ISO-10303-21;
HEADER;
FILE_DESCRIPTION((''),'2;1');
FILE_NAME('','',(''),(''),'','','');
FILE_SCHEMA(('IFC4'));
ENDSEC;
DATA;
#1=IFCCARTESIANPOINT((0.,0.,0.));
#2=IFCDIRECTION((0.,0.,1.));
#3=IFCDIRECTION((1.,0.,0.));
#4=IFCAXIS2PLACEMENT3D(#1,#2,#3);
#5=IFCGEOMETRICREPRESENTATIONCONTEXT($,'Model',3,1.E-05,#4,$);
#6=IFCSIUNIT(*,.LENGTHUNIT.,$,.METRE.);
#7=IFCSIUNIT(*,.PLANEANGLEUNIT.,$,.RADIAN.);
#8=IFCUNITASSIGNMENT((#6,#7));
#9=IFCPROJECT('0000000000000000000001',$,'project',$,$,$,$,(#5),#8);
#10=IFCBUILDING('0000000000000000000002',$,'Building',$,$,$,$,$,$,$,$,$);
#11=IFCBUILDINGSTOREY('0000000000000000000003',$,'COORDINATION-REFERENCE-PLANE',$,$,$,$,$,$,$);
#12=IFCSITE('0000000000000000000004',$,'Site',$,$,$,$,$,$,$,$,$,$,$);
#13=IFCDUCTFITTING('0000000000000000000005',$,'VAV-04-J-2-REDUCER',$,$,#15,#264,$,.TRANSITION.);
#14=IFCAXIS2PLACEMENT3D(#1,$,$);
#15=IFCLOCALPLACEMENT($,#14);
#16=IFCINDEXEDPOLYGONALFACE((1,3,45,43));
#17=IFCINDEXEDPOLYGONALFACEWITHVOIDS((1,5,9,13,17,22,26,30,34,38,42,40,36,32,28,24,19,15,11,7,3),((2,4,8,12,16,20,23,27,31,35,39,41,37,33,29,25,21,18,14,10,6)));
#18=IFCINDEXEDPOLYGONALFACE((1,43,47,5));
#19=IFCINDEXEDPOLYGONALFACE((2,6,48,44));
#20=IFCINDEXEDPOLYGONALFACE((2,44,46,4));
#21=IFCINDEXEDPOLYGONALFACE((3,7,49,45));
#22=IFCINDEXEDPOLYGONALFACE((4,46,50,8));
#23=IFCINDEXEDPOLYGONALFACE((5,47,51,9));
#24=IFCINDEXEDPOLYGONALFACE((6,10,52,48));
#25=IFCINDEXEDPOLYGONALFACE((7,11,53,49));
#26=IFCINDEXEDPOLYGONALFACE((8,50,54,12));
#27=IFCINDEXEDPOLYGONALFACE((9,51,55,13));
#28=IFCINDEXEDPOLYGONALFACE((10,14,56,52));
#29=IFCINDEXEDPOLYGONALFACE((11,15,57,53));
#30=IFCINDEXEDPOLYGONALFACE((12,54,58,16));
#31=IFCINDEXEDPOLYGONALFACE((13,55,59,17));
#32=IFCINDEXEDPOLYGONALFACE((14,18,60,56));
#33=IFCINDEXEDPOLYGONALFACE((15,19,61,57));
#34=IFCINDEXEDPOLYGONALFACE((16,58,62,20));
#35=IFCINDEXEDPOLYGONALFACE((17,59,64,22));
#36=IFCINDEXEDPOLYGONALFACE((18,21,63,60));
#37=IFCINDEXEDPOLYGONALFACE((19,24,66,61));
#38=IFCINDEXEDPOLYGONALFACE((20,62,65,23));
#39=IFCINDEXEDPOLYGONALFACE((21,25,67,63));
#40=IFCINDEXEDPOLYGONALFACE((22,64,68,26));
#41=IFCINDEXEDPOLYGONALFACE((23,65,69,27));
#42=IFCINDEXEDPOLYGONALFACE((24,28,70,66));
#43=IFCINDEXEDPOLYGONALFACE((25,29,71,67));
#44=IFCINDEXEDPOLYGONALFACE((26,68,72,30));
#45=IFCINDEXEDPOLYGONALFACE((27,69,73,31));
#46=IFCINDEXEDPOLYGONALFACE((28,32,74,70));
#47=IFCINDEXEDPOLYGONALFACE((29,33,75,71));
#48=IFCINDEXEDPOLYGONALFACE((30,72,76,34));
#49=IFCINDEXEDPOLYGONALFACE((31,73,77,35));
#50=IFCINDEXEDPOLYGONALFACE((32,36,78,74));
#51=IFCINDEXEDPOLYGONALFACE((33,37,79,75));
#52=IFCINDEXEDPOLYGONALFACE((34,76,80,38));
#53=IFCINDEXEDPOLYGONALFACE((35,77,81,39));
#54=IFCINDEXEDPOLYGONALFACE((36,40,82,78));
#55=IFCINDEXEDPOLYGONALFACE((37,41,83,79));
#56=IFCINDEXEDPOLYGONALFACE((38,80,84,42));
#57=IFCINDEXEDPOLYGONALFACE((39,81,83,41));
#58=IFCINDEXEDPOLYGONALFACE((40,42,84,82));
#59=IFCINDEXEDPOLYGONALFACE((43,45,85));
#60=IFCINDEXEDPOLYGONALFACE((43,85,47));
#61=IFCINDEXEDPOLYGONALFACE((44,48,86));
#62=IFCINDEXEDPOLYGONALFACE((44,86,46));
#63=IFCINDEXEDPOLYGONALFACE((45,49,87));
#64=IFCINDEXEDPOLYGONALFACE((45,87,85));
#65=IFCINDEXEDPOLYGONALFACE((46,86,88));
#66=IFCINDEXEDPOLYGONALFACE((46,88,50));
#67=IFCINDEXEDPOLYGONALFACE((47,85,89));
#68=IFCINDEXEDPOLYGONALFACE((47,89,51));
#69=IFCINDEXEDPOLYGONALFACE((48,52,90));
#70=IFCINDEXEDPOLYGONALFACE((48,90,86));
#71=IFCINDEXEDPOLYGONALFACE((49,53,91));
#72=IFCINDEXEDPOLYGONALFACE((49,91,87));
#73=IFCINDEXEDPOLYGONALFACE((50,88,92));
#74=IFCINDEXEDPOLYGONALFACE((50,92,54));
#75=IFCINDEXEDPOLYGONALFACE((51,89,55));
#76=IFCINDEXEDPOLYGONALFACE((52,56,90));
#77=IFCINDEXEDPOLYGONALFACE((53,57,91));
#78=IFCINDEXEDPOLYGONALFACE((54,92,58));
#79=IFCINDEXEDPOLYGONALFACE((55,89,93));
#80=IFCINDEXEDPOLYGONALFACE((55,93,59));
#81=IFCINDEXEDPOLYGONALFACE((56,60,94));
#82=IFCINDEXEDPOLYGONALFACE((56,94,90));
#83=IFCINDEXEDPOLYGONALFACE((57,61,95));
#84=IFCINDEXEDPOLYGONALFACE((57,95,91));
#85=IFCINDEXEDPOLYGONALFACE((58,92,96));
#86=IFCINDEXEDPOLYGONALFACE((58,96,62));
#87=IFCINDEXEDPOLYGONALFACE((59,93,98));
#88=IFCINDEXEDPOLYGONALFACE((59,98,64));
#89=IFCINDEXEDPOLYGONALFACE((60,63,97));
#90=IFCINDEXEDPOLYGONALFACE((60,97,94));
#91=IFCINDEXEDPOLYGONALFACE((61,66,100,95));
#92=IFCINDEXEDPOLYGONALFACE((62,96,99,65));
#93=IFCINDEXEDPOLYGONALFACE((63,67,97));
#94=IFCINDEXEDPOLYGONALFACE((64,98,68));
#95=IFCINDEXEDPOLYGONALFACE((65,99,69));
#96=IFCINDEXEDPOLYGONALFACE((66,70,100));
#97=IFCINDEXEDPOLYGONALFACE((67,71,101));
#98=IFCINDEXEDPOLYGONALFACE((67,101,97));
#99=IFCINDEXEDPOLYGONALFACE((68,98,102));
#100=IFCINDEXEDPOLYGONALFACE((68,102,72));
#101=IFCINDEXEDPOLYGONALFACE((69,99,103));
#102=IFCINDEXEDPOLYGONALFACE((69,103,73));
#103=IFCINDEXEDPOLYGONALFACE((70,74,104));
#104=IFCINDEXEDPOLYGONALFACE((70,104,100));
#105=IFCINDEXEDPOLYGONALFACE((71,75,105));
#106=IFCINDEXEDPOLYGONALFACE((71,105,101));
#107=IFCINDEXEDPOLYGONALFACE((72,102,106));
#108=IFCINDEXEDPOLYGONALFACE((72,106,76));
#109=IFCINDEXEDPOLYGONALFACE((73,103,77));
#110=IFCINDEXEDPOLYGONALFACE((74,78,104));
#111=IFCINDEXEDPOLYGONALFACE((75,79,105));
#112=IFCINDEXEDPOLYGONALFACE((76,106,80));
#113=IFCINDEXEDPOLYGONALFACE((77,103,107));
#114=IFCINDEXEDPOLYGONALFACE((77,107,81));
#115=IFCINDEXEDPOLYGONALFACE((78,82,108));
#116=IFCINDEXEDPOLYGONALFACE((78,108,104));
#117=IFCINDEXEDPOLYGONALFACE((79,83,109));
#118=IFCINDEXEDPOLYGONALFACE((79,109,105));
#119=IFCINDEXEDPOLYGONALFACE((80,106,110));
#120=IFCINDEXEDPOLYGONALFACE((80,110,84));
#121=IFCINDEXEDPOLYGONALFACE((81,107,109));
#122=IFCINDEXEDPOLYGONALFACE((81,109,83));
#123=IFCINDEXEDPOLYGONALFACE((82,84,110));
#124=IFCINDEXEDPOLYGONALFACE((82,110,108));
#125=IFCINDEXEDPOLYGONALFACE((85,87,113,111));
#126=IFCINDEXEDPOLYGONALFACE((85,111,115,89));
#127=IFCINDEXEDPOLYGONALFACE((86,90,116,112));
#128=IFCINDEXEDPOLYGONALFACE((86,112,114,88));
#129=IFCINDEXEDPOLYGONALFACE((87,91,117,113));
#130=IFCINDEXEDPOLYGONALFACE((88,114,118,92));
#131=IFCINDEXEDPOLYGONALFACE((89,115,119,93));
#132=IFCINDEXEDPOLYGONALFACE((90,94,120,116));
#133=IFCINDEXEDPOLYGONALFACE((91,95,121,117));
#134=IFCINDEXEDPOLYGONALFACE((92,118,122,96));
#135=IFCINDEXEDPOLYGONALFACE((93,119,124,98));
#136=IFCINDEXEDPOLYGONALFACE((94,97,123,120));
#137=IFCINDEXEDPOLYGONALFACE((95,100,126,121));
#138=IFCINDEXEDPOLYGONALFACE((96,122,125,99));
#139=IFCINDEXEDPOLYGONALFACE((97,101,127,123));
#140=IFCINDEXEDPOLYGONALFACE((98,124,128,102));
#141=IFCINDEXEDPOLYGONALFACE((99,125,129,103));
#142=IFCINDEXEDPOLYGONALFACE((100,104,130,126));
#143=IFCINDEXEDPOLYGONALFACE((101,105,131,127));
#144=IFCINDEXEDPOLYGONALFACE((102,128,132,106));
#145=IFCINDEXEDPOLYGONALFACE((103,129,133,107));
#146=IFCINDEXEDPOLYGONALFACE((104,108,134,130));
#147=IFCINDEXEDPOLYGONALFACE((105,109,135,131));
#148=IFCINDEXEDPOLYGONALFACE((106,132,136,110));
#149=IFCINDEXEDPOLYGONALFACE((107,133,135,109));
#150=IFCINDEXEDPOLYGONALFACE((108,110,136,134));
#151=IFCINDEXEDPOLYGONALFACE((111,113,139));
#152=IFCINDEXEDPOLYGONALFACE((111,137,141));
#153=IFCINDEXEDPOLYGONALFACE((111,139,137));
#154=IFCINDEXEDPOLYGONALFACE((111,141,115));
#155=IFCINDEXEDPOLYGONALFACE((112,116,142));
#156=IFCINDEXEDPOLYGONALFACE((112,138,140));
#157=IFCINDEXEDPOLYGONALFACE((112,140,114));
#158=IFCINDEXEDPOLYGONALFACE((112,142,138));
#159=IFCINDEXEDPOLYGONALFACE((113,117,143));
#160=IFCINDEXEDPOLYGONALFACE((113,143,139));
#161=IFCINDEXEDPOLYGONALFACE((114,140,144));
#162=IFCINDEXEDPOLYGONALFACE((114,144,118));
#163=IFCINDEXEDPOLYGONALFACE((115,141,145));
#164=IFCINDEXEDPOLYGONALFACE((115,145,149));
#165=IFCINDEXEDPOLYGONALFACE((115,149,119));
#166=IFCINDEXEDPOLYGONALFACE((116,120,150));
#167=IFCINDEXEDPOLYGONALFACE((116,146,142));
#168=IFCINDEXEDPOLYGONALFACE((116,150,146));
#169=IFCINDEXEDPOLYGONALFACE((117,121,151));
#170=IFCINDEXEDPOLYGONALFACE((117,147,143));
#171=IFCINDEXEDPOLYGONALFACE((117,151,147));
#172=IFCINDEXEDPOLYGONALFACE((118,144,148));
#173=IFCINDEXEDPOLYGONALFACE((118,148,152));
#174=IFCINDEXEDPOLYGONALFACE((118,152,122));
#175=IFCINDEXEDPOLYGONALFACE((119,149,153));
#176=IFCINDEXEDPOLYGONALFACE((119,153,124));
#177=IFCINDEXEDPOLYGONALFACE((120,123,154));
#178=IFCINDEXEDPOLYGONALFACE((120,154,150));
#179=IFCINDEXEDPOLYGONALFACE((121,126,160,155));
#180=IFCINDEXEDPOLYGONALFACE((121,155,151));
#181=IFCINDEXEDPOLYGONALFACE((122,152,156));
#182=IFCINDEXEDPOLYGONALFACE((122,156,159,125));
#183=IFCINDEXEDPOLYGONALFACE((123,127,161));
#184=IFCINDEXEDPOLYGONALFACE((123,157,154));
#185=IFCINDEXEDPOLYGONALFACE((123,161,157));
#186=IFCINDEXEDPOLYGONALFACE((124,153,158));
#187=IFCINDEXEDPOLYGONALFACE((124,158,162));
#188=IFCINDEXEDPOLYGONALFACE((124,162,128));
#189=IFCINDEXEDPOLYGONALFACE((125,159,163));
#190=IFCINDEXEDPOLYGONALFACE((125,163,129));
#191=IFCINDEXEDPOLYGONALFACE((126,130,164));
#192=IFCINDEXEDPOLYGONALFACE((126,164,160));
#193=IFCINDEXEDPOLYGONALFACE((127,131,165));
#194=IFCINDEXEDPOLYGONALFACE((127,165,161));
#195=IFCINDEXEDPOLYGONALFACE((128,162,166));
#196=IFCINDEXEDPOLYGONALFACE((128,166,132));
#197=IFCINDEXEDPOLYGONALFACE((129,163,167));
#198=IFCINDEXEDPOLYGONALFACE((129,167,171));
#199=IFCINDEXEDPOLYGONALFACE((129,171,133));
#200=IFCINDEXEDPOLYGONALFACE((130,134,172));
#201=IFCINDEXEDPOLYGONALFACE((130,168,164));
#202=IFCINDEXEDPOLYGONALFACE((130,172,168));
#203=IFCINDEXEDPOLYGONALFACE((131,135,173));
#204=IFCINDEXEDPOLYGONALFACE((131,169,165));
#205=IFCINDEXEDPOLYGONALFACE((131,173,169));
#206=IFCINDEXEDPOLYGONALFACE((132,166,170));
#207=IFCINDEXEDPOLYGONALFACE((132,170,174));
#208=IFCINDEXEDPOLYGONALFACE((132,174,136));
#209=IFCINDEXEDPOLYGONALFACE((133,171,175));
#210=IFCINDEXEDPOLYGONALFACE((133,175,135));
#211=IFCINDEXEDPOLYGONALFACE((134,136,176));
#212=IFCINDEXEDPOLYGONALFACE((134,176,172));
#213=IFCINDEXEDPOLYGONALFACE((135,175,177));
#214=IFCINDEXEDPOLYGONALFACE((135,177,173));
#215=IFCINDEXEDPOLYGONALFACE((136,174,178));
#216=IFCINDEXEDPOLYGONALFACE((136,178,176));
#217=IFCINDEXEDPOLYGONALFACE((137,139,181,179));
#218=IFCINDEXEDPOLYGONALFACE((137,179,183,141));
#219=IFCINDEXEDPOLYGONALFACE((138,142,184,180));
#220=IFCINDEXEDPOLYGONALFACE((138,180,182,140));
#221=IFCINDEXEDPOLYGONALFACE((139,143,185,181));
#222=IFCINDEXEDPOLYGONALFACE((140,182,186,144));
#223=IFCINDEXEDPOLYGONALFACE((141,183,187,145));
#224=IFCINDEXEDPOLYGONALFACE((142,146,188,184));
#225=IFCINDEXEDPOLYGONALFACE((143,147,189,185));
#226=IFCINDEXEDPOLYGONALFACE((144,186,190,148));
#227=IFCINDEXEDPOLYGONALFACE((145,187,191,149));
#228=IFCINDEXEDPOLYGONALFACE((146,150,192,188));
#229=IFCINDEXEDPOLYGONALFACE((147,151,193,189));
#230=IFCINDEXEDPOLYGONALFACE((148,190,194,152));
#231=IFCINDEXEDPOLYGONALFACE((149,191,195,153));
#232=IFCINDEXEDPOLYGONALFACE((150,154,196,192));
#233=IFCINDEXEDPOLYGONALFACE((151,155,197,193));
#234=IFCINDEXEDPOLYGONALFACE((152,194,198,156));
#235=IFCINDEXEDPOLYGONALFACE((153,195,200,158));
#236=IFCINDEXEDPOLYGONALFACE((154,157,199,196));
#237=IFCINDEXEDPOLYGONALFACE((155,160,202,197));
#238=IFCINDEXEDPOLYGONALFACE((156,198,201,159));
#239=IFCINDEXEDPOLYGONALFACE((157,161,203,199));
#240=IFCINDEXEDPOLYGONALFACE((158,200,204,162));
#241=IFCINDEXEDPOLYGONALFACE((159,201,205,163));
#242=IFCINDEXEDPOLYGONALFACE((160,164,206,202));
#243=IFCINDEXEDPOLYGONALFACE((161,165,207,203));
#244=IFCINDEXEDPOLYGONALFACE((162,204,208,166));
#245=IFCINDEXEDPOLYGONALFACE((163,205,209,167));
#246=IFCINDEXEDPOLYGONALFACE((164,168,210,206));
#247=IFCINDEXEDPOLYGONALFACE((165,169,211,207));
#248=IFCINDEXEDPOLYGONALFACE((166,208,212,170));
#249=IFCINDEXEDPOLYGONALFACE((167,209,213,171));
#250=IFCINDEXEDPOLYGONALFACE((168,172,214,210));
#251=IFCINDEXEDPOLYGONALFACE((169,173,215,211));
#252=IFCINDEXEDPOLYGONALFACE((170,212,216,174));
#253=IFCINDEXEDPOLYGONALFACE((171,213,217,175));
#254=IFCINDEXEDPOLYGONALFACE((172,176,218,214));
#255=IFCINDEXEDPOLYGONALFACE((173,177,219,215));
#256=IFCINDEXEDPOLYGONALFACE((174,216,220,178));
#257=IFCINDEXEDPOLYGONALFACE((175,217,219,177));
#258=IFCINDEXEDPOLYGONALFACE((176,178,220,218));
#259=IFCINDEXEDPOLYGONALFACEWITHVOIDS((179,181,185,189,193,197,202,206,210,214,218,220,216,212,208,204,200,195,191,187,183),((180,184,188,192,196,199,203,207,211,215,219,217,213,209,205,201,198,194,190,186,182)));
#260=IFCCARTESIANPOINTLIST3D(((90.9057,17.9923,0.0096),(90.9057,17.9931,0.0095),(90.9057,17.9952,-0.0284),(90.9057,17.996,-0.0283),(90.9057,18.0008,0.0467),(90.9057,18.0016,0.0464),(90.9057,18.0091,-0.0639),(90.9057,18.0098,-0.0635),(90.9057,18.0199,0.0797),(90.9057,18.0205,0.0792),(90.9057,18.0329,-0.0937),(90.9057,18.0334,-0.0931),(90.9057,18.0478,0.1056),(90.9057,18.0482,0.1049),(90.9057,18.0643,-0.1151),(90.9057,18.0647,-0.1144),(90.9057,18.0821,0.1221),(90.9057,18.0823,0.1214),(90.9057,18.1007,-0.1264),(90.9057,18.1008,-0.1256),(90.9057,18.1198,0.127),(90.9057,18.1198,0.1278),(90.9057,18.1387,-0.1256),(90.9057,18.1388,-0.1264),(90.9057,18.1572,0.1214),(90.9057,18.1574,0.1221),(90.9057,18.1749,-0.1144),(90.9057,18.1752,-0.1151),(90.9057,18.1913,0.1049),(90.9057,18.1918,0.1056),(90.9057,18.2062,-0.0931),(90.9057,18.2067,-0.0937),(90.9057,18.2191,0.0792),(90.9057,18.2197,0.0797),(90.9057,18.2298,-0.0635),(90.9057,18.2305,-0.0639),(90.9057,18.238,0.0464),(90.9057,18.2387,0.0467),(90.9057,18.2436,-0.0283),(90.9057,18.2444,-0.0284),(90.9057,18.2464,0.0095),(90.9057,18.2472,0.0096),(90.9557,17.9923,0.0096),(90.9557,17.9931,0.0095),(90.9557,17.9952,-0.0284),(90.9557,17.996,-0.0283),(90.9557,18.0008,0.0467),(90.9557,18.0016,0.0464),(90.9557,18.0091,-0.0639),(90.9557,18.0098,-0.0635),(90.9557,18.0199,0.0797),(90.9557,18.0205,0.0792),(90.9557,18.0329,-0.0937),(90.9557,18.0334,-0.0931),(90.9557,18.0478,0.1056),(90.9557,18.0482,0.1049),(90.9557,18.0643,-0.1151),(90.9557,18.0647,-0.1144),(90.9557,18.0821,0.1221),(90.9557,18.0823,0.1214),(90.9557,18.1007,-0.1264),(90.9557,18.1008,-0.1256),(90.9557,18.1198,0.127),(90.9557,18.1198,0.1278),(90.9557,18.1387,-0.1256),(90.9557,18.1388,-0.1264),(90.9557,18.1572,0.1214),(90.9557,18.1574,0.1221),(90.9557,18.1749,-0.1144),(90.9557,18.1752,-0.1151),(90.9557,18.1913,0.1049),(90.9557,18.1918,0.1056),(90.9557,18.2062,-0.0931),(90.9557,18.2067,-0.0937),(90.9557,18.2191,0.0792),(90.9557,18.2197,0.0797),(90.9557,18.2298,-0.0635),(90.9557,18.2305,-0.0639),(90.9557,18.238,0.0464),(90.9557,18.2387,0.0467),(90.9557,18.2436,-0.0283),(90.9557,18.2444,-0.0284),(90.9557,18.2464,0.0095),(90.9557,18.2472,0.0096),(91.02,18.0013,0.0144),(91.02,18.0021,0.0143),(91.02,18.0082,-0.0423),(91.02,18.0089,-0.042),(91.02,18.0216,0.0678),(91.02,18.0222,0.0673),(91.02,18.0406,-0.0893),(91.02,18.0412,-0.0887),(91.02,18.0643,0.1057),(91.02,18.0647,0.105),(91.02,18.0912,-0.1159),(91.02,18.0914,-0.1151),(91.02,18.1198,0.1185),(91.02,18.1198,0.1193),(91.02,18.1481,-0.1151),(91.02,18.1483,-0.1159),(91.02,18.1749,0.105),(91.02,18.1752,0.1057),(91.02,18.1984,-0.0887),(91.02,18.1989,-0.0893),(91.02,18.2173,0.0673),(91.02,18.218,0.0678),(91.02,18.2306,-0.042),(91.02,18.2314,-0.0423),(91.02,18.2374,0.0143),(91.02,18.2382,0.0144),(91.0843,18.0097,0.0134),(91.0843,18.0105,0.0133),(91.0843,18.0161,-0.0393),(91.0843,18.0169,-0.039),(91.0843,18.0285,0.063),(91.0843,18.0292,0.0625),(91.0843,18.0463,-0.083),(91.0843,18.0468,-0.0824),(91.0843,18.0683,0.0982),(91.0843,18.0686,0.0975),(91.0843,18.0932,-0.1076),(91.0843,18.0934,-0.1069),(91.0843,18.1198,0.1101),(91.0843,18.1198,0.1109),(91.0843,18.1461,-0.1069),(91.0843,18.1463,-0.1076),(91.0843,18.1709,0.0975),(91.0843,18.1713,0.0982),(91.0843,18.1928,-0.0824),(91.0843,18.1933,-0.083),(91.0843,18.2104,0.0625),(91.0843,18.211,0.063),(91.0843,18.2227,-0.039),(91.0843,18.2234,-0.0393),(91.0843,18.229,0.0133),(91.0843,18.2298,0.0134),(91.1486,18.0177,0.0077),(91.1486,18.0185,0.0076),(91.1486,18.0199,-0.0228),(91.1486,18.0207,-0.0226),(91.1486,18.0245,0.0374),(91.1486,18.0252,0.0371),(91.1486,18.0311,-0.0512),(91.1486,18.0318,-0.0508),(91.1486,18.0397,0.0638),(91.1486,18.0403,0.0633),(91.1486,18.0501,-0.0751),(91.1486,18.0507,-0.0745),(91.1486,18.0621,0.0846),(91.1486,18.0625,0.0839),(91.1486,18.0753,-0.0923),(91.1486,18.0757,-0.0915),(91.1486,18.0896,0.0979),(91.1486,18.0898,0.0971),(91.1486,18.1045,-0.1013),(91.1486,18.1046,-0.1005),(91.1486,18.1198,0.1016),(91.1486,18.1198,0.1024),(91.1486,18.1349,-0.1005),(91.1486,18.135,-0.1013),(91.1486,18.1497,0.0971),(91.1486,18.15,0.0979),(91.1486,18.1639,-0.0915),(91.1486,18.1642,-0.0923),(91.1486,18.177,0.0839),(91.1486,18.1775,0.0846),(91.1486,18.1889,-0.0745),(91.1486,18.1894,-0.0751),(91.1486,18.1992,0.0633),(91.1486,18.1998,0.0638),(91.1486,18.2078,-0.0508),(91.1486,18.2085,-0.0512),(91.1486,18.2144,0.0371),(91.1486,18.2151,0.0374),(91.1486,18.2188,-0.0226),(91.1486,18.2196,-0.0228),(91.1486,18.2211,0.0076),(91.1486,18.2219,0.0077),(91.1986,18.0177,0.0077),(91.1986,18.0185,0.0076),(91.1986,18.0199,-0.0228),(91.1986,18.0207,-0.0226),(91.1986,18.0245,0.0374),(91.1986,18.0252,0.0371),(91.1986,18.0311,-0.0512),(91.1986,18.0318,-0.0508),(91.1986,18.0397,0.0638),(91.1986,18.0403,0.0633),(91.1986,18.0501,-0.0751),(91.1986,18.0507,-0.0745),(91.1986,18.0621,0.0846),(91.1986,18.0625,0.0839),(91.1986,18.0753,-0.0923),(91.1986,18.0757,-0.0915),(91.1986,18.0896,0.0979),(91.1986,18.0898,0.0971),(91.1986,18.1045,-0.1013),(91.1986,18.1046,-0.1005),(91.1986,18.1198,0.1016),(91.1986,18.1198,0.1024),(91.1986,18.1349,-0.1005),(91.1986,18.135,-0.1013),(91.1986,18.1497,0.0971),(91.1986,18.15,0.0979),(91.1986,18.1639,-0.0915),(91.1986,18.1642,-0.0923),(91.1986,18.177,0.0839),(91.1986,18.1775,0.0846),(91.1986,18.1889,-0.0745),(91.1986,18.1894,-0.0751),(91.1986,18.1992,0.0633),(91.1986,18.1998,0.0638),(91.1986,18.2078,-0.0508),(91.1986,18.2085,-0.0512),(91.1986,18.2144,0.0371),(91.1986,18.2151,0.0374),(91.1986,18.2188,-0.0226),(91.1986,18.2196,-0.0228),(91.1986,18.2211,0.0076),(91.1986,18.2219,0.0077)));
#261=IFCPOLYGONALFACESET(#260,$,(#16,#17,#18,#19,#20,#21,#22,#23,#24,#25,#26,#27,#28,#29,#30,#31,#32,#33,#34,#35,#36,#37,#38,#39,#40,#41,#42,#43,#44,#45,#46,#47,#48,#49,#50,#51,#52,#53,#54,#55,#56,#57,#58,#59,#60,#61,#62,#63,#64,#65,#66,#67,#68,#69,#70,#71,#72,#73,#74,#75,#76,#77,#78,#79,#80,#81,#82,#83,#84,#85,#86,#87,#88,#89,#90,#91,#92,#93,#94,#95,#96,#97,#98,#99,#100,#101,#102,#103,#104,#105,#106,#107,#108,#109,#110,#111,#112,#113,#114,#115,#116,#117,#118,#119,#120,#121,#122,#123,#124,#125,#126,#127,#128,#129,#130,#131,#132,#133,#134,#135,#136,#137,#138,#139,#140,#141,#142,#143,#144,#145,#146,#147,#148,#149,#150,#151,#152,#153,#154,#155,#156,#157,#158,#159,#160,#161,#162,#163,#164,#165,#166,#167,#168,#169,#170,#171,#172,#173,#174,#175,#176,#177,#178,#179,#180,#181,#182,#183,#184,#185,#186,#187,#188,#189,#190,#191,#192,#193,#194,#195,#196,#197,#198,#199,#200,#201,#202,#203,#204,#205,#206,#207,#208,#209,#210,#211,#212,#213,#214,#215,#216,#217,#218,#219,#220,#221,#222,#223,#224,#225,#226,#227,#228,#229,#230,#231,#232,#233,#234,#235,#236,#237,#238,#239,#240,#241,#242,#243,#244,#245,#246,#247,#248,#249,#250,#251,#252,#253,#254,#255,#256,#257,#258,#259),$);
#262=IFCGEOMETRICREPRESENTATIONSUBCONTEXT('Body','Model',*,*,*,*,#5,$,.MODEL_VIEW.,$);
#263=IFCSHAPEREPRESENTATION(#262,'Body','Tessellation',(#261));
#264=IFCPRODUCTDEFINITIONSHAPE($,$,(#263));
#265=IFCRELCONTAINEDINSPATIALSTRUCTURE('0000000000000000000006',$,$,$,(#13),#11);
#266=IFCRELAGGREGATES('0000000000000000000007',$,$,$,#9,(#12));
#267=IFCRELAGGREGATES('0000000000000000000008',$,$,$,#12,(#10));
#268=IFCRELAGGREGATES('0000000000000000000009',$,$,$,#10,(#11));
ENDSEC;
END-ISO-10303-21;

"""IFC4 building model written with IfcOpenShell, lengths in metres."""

from ifc_helpers import new_model, entity, si_unit, frame, origin_with_axes, place, context, subcontext, project, spatial, element, save


model = new_model("IFC4")

# Units and contexts
model_context = context("Model", 3, precision=1e-05, world=origin_with_axes())
body_context_1 = subcontext(model_context, "Body", "Model", "MODEL_VIEW")
ifc_project = project(units=[si_unit("LENGTHUNIT", "METRE"), si_unit("PLANEANGLEUNIT", "RADIAN")], contexts=[model_context])

# Site, building, storey
site = spatial("IfcSite", under=ifc_project, Name="Site")
building = spatial("IfcBuilding", under=site, Name="Building")
storey = spatial("IfcBuildingStorey", under=building, Name="COORDINATION-REFERENCE-PLANE")

# Duct fitting
for number, where, z_axis, x_axis, name in (
    (1, (90.9057, 18.1198, 0.0), (0.0, 1.0, 0.0), (0.0, 0.0, 1.0), "VAV-04-J-2-REDUCER"),
):
    element("IfcDuctFitting", number, at=place(None, frame(where, z_axis=z_axis, x_axis=x_axis)), inside=storey, Name=name, PredefinedType="TRANSITION", context=body_context_1, shape_type="SweptSolid", body=[
        entity("IfcRevolvedAreaSolid", entity("IfcArbitraryClosedProfileDef", "AREA", None, entity("IfcPolyline", [entity("IfcCartesianPoint", [0.1278, 0.0]), entity("IfcCartesianPoint", [0.1278, 0.05]), entity("IfcCartesianPoint", [0.1024, 0.2429]), entity("IfcCartesianPoint", [0.1024, 0.2929]), entity("IfcCartesianPoint", [0.1016, 0.2929]), entity("IfcCartesianPoint", [0.1016, 0.2429]), entity("IfcCartesianPoint", [0.127, 0.05]), entity("IfcCartesianPoint", [0.127, 0.0]), entity("IfcCartesianPoint", [0.1278, 0.0])])), entity("IfcAxis2Placement3D", entity("IfcCartesianPoint", [0.0, 0.0, 0.0])), entity("IfcAxis1Placement", entity("IfcCartesianPoint", [0.0, 0.0, 0.0]), entity("IfcDirection", [0.0, 1.0, 0.0])), 6.283185),
    ])

save(model, "model.ifc")
